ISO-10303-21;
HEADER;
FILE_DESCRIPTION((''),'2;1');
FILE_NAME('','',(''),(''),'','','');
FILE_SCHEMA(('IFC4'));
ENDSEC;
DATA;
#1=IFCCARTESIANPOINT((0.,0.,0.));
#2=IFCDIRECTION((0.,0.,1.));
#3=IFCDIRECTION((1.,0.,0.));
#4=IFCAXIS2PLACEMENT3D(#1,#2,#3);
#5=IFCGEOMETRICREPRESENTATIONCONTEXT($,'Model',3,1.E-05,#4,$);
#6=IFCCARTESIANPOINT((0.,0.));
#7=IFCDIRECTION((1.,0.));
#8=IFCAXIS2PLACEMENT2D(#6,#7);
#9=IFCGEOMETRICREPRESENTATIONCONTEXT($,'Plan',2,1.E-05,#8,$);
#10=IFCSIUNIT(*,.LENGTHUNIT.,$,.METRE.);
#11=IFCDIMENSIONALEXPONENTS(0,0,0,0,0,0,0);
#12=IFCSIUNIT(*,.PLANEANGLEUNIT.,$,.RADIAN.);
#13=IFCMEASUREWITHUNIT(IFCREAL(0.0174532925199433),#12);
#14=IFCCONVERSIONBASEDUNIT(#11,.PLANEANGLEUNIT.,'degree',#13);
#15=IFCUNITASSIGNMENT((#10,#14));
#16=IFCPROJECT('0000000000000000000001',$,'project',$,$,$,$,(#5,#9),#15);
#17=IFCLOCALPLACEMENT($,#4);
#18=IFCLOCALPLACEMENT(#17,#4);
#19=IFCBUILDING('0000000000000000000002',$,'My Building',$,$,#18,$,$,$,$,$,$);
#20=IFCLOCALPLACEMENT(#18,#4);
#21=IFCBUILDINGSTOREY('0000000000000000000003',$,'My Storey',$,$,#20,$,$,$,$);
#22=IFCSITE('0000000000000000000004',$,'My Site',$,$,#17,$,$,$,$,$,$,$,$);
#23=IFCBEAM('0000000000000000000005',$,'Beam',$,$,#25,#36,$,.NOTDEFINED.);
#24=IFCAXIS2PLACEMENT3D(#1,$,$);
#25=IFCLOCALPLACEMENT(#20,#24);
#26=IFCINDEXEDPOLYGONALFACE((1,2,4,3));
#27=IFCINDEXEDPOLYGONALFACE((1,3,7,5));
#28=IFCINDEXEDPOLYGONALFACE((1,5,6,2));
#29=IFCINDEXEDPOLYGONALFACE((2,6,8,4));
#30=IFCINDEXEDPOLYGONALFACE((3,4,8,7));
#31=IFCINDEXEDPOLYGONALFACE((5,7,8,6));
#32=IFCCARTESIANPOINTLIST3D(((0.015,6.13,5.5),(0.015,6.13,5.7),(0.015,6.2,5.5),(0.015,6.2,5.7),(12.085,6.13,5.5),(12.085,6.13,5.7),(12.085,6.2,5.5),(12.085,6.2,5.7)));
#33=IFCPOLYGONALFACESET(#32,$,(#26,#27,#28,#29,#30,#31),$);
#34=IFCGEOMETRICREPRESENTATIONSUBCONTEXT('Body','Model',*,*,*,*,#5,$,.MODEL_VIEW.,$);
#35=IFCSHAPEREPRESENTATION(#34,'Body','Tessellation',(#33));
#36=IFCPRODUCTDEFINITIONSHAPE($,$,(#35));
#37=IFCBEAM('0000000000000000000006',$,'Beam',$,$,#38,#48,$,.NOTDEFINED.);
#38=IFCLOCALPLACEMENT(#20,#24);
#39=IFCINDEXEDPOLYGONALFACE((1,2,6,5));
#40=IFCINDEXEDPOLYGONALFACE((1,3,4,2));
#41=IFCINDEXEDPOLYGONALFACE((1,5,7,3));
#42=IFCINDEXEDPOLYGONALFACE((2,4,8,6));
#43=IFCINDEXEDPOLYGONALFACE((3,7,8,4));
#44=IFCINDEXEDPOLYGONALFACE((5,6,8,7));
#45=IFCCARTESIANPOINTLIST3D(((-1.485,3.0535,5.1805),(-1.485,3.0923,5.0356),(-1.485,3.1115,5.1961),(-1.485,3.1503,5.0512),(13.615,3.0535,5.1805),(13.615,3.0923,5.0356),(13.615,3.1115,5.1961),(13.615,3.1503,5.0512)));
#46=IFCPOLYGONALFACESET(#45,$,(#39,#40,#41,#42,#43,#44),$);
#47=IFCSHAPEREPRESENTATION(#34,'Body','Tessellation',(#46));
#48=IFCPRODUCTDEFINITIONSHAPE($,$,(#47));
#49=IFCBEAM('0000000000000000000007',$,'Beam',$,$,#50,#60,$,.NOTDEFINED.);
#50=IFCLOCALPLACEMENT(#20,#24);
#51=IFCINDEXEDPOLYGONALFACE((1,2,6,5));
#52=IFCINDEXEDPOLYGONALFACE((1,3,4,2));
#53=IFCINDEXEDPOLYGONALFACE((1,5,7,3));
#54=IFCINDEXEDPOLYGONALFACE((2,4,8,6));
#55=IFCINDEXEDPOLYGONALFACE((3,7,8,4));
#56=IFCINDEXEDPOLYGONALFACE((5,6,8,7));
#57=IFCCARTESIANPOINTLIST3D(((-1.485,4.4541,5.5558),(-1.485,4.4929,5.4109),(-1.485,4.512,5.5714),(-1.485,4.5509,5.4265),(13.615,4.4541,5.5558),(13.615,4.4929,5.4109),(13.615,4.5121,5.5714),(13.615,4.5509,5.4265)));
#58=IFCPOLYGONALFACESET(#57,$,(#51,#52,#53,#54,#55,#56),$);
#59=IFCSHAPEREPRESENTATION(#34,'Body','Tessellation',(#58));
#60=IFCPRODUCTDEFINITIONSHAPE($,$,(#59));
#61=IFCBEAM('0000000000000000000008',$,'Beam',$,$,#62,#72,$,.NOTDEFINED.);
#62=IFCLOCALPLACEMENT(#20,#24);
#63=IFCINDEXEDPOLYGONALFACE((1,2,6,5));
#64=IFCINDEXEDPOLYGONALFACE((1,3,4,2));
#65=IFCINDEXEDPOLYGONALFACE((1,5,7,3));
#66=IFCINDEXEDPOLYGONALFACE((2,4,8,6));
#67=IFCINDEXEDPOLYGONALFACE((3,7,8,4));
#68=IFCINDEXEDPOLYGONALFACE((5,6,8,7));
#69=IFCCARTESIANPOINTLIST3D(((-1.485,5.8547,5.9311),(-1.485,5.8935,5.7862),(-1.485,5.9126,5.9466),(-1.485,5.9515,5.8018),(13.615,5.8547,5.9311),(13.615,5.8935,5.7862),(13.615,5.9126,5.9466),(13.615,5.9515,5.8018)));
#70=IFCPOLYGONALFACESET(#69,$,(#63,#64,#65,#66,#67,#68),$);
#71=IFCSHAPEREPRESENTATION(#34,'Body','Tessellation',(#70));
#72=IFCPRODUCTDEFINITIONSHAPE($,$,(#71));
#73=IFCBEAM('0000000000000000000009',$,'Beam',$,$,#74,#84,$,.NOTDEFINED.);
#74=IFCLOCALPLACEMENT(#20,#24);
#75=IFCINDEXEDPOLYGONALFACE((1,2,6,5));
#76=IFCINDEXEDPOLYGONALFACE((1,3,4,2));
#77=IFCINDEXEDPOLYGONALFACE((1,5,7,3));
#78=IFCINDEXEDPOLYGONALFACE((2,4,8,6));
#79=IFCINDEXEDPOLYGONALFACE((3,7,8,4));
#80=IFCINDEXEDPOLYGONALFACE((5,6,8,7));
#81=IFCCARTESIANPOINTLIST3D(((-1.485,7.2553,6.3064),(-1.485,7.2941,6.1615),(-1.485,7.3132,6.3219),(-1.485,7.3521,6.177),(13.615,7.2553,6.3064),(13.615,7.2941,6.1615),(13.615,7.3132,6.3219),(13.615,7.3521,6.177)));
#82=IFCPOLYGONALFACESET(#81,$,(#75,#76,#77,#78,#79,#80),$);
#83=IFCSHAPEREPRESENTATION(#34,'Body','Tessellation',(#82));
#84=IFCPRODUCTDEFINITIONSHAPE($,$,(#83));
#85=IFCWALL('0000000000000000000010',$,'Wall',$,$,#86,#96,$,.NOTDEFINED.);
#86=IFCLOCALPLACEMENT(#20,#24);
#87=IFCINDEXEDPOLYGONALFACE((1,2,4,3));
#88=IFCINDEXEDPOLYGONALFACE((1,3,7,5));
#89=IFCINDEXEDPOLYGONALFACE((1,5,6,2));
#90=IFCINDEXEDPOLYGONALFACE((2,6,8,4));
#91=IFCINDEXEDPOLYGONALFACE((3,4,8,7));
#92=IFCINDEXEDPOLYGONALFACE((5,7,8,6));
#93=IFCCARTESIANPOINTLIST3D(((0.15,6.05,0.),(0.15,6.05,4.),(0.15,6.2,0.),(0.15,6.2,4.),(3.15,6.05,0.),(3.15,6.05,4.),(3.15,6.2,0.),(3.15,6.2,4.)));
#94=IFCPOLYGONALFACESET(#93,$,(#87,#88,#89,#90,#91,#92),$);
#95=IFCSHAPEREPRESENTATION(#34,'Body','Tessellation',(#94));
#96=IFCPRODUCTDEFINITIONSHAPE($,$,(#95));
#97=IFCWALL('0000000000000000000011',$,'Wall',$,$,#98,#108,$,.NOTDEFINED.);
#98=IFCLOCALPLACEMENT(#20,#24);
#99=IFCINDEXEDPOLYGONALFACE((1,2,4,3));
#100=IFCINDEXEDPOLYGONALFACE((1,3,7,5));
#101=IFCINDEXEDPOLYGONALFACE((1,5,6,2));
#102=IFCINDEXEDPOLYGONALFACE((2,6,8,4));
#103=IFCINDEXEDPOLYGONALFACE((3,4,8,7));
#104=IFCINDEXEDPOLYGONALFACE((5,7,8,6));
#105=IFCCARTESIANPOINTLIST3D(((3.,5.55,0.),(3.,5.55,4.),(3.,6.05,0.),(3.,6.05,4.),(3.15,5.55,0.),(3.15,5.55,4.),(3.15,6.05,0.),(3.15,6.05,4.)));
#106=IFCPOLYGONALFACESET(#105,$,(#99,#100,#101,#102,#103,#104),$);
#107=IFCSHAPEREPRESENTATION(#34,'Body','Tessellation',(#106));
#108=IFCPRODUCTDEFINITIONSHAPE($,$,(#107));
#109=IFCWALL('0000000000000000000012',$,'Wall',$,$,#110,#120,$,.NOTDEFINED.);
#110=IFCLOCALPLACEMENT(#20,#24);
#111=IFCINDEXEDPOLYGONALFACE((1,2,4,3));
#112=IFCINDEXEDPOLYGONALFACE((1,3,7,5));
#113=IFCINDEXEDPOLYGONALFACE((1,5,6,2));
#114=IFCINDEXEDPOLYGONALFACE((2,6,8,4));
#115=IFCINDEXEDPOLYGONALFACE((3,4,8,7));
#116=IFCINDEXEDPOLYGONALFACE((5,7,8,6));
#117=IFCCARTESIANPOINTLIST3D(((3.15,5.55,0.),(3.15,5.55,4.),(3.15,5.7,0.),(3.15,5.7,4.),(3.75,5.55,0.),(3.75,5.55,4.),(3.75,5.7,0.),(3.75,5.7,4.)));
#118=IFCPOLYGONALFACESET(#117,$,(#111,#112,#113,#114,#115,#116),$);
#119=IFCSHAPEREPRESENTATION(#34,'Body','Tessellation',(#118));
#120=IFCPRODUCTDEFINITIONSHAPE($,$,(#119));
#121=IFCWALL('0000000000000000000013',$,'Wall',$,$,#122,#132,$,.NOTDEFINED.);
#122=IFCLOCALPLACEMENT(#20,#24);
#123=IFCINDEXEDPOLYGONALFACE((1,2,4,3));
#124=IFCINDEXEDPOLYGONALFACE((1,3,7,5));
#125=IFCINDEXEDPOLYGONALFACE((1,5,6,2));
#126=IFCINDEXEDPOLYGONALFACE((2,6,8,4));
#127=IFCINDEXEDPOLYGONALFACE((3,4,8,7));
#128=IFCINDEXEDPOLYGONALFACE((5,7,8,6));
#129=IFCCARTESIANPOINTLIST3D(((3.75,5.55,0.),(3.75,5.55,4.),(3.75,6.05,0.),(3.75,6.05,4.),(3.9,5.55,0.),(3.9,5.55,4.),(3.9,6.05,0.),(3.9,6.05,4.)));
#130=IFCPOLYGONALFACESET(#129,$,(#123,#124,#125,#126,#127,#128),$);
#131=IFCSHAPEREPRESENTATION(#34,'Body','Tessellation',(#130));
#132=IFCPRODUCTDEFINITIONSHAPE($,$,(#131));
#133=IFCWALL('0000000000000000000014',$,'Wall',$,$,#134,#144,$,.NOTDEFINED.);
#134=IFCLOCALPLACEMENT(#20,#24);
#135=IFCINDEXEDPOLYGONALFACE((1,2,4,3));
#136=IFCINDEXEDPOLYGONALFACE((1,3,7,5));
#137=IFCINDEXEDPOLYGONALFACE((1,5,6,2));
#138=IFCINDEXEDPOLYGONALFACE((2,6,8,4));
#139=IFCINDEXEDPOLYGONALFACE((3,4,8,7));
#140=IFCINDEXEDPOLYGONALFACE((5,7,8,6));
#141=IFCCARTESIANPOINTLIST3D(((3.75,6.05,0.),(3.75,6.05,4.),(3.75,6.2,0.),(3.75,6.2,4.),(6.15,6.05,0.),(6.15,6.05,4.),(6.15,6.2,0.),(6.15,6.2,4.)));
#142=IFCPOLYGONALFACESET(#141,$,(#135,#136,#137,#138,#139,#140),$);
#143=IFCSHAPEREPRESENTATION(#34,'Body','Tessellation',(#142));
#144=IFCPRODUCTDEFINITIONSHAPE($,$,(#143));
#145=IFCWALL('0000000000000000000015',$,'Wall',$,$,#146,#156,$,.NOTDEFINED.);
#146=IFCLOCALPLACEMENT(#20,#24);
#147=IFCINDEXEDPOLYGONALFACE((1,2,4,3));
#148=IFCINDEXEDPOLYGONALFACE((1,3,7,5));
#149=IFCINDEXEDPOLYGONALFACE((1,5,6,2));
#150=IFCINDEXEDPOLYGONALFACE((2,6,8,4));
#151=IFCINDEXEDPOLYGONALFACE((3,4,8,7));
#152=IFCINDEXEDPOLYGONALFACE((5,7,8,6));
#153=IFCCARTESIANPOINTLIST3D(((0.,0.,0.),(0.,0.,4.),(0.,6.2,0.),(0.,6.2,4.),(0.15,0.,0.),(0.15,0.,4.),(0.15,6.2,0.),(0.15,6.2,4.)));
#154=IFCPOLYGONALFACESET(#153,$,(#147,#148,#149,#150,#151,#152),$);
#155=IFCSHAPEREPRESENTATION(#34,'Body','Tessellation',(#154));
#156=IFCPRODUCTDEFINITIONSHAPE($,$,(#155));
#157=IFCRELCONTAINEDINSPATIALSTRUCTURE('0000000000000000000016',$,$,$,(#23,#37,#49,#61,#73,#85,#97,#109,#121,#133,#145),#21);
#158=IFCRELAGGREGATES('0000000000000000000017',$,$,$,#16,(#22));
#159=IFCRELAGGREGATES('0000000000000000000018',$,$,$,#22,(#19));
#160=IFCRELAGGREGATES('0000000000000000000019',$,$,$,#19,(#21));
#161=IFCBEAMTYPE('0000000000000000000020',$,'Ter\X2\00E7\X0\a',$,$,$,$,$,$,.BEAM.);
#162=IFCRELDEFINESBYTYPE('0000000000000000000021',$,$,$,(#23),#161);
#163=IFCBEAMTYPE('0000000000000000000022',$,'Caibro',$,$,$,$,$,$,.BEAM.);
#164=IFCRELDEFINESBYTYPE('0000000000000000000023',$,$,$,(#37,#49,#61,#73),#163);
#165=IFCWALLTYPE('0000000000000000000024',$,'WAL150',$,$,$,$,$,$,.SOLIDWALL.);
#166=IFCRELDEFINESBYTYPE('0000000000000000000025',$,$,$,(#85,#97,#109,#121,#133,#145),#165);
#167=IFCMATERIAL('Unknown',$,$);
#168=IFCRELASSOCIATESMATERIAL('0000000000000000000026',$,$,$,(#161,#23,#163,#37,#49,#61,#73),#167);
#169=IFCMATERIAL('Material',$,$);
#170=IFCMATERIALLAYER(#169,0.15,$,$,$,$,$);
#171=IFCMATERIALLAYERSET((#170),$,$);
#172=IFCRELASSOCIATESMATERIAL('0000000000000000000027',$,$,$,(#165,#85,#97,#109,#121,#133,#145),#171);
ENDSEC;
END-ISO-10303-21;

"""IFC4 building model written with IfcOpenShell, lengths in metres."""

from ifc_helpers import new_model, entity, si_unit, converted_unit, frame, origin_with_axes, origin_2d_with_axis, place, context, subcontext, project, spatial, indexed_curve, rectangle, outline, extrude, material, layer, layer_set, layer_usage, material_profile, profile_set, profile_usage, type_object, element, save


model = new_model("IFC4")

# Units and contexts
model_context = context("Model", 3, precision=1e-05, world=origin_with_axes())
plan_context = context("Plan", 2, precision=1e-05, world=origin_2d_with_axis())
body_context = subcontext(model_context, "Body", "Model", "MODEL_VIEW")
ifc_project = project(units=[si_unit("LENGTHUNIT", "METRE"), converted_unit("PLANEANGLEUNIT", "degree", entity("IfcReal", 0.0174532925199433), si_unit("PLANEANGLEUNIT", "RADIAN"), dimensions=[0, 0, 0, 0, 0, 0, 0])], contexts=[model_context, plan_context])

# Site, building, storey
site_placement = place(None, origin_with_axes())
site = spatial("IfcSite", under=ifc_project, at=site_placement, Name="My Site")
building_placement = place(site_placement, origin_with_axes())
building = spatial("IfcBuilding", under=site, at=building_placement, Name="My Building")
storey_placement = place(building_placement, origin_with_axes())
storey = spatial("IfcBuildingStorey", under=building, at=storey_placement, Name="My Storey")

# Shared definitions
ifc_material_1 = material(Name="Unknown")

# Beams
ifc_material_profile_1 = material_profile(ifc_material_1, rectangle(XDim=0.07, YDim=0.2))
ifc_profile_set_1 = profile_set([ifc_material_profile_1])
beam_type_1 = type_object("IfcBeamType", Name="Terça", PredefinedType="BEAM", material=ifc_profile_set_1)
ifc_profile_usage_1 = profile_usage(ifc_profile_set_1, cardinal=2)
beam_1_placement = place(storey_placement, frame((0.015, 6.165, 5.5), z_axis=(1.0, 0.0, 0.0), x_axis=(0.0, 1.0, 0.0)))
element("IfcBeam", 1, at=beam_1_placement, inside=storey, type_object=beam_type_1, material=ifc_profile_usage_1, Name="Beam", PredefinedType="NOTDEFINED", context=body_context, shape_type="SweptSolid", body=[
    extrude(rectangle(XDim=0.07, YDim=0.2), frame((0.0, 0.1, 0.0), z_axis=(0.0, 0.0, 1.0), x_axis=(1.0, 0.0, 0.0)), (0.0, 0.0, 1.0), 12.07),
])
ifc_material_profile_2 = material_profile(ifc_material_1, rectangle(XDim=0.06, YDim=0.15))
ifc_profile_set_2 = profile_set([ifc_material_profile_2])
ifc_profile_usage_2 = profile_usage(ifc_profile_set_2, cardinal=2)
beam_type_2 = type_object("IfcBeamType", Name="Caibro", PredefinedType="BEAM", material=ifc_profile_set_2)
beam_2_placement = place(storey_placement, frame((-1.485, 3.1213, 5.0434), z_axis=(1.0, 0.0, 0.0), x_axis=(0.0, 0.965926, 0.25882)))
element("IfcBeam", 2, at=beam_2_placement, inside=storey, type_object=beam_type_2, material=ifc_profile_usage_2, Name="Beam", PredefinedType="NOTDEFINED", context=body_context, shape_type="SweptSolid", body=[
    extrude(rectangle(XDim=0.06, YDim=0.15), frame((0.0, 0.075, 0.0), z_axis=(0.0, 0.0, 1.0), x_axis=(1.0, 0.0, 0.0)), (0.0, 0.0, 1.0), 15.1),
])
ifc_profile_usage_3 = profile_usage(ifc_profile_set_2, cardinal=2)
beam_3_placement = place(storey_placement, frame((-1.485, 4.5219, 5.4187), z_axis=(1.0, 0.0, 0.0), x_axis=(0.0, 0.965926, 0.25882)))
element("IfcBeam", 3, at=beam_3_placement, inside=storey, type_object=beam_type_2, material=ifc_profile_usage_3, Name="Beam", PredefinedType="NOTDEFINED", context=body_context, shape_type="SweptSolid", body=[
    extrude(rectangle(XDim=0.06, YDim=0.15), frame((0.0, 0.075, 0.0), z_axis=(0.0, 0.0, 1.0), x_axis=(1.0, 0.0, 0.0)), (0.0, 0.0, 1.0), 15.1),
])
ifc_profile_usage_4 = profile_usage(ifc_profile_set_2, cardinal=2)
beam_4_placement = place(storey_placement, frame((-1.485, 5.9225, 5.794), z_axis=(1.0, 0.0, 0.0), x_axis=(0.0, 0.965926, 0.25882)))
element("IfcBeam", 4, at=beam_4_placement, inside=storey, type_object=beam_type_2, material=ifc_profile_usage_4, Name="Beam", PredefinedType="NOTDEFINED", context=body_context, shape_type="SweptSolid", body=[
    extrude(rectangle(XDim=0.06, YDim=0.15), frame((0.0, 0.075, 0.0), z_axis=(0.0, 0.0, 1.0), x_axis=(1.0, 0.0, 0.0)), (0.0, 0.0, 1.0), 15.1),
])
ifc_profile_usage_5 = profile_usage(ifc_profile_set_2, cardinal=2)
beam_5_placement = place(storey_placement, frame((-1.485, 7.3231, 6.1693), z_axis=(1.0, 0.0, 0.0), x_axis=(0.0, 0.965926, 0.25882)))
element("IfcBeam", 5, at=beam_5_placement, inside=storey, type_object=beam_type_2, material=ifc_profile_usage_5, Name="Beam", PredefinedType="NOTDEFINED", context=body_context, shape_type="SweptSolid", body=[
    extrude(rectangle(XDim=0.06, YDim=0.15), frame((0.0, 0.075, 0.0), z_axis=(0.0, 0.0, 1.0), x_axis=(1.0, 0.0, 0.0)), (0.0, 0.0, 1.0), 15.1),
])

# Walls
ifc_material_2 = material(Name="Material")
ifc_layer = layer(ifc_material_2, 0.15)
ifc_layer_set = layer_set([ifc_layer])
ifc_layer_usage_1 = layer_usage(ifc_layer_set, "AXIS2", "POSITIVE", 0.0)
wall_type = type_object("IfcWallType", Name="WAL150", PredefinedType="SOLIDWALL", material=ifc_layer_set)
wall_1_placement = place(storey_placement, frame((3.15, 6.2, 0.0), z_axis=(0.0, 0.0, 1.0), x_axis=(-1.0, 0.0, 0.0)))
element("IfcWall", 6, at=wall_1_placement, inside=storey, type_object=wall_type, material=ifc_layer_usage_1, Name="Wall", PredefinedType="NOTDEFINED", context=body_context, shape_type="SweptSolid", body=[
    extrude(outline(indexed_curve([(0.0, 0.0), (0.0, 0.15), (3.0, 0.15), (3.0, 0.0), (0.0, 0.0)], self_intersect=False)), origin_with_axes(), (0.0, 0.0, 1.0), 4.0),
])
ifc_layer_usage_2 = layer_usage(ifc_layer_set, "AXIS2", "POSITIVE", 0.0)
wall_2_placement = place(storey_placement, frame((3.0, 6.05, 0.0), z_axis=(0.0, 0.0, 1.0), x_axis=(-0.000001, -1.0, 0.0)))
element("IfcWall", 7, at=wall_2_placement, inside=storey, type_object=wall_type, material=ifc_layer_usage_2, Name="Wall", PredefinedType="NOTDEFINED", context=body_context, shape_type="SweptSolid", body=[
    extrude(outline(indexed_curve([(0.0, 0.0), (0.0, 0.15), (0.5, 0.15), (0.5, 0.0), (0.0, 0.0)], self_intersect=False)), origin_with_axes(), (0.0, 0.0, 1.0), 4.0),
])
ifc_layer_usage_3 = layer_usage(ifc_layer_set, "AXIS2", "POSITIVE", 0.0)
wall_3_placement = place(storey_placement, frame((3.15, 5.55, 0.0), z_axis=(0.0, 0.0, 1.0), x_axis=(1.0, -0.000001, 0.0)))
element("IfcWall", 8, at=wall_3_placement, inside=storey, type_object=wall_type, material=ifc_layer_usage_3, Name="Wall", PredefinedType="NOTDEFINED", context=body_context, shape_type="SweptSolid", body=[
    extrude(outline(indexed_curve([(0.0, 0.0), (0.0, 0.15), (0.6, 0.15), (0.6, 0.0), (0.0, 0.0)], self_intersect=False)), origin_with_axes(), (0.0, 0.0, 1.0), 4.0),
])
ifc_layer_usage_4 = layer_usage(ifc_layer_set, "AXIS2", "POSITIVE", 0.0)
wall_4_placement = place(storey_placement, frame((3.75, 6.05, 0.0), z_axis=(0.0, 0.0, 1.0), x_axis=(-0.000001, -1.0, 0.0)))
element("IfcWall", 9, at=wall_4_placement, inside=storey, type_object=wall_type, material=ifc_layer_usage_4, Name="Wall", PredefinedType="NOTDEFINED", context=body_context, shape_type="SweptSolid", body=[
    extrude(outline(indexed_curve([(0.0, 0.0), (0.0, 0.15), (0.5, 0.15), (0.5, 0.0), (0.0, 0.0)], self_intersect=False)), origin_with_axes(), (0.0, 0.0, 1.0), 4.0),
])
ifc_layer_usage_5 = layer_usage(ifc_layer_set, "AXIS2", "POSITIVE", 0.0)
wall_5_placement = place(storey_placement, frame((3.75, 6.05, 0.0), z_axis=(0.0, 0.0, 1.0), x_axis=(1.0, -0.000001, 0.0)))
element("IfcWall", 10, at=wall_5_placement, inside=storey, type_object=wall_type, material=ifc_layer_usage_5, Name="Wall", PredefinedType="NOTDEFINED", context=body_context, shape_type="SweptSolid", body=[
    extrude(outline(indexed_curve([(0.0, 0.0), (0.0, 0.15), (2.4, 0.15), (2.4, 0.0), (0.0, 0.0)], self_intersect=False)), origin_with_axes(), (0.0, 0.0, 1.0), 4.0),
])
ifc_layer_usage_6 = layer_usage(ifc_layer_set, "AXIS2", "POSITIVE", 0.0)
wall_6_placement = place(storey_placement, frame((0.0, 6.2, 0.0), z_axis=(0.0, 0.0, 1.0), x_axis=(0.0, -1.0, 0.0)))
element("IfcWall", 11, at=wall_6_placement, inside=storey, type_object=wall_type, material=ifc_layer_usage_6, Name="Wall", PredefinedType="NOTDEFINED", context=body_context, shape_type="SweptSolid", body=[
    extrude(outline(indexed_curve([(0.0, 0.0), (0.0, 0.15), (6.2, 0.15), (6.2, 0.0), (0.0, 0.0)], self_intersect=False)), origin_with_axes(), (0.0, 0.0, 1.0), 4.0),
])

save(model, "model.ifc")
